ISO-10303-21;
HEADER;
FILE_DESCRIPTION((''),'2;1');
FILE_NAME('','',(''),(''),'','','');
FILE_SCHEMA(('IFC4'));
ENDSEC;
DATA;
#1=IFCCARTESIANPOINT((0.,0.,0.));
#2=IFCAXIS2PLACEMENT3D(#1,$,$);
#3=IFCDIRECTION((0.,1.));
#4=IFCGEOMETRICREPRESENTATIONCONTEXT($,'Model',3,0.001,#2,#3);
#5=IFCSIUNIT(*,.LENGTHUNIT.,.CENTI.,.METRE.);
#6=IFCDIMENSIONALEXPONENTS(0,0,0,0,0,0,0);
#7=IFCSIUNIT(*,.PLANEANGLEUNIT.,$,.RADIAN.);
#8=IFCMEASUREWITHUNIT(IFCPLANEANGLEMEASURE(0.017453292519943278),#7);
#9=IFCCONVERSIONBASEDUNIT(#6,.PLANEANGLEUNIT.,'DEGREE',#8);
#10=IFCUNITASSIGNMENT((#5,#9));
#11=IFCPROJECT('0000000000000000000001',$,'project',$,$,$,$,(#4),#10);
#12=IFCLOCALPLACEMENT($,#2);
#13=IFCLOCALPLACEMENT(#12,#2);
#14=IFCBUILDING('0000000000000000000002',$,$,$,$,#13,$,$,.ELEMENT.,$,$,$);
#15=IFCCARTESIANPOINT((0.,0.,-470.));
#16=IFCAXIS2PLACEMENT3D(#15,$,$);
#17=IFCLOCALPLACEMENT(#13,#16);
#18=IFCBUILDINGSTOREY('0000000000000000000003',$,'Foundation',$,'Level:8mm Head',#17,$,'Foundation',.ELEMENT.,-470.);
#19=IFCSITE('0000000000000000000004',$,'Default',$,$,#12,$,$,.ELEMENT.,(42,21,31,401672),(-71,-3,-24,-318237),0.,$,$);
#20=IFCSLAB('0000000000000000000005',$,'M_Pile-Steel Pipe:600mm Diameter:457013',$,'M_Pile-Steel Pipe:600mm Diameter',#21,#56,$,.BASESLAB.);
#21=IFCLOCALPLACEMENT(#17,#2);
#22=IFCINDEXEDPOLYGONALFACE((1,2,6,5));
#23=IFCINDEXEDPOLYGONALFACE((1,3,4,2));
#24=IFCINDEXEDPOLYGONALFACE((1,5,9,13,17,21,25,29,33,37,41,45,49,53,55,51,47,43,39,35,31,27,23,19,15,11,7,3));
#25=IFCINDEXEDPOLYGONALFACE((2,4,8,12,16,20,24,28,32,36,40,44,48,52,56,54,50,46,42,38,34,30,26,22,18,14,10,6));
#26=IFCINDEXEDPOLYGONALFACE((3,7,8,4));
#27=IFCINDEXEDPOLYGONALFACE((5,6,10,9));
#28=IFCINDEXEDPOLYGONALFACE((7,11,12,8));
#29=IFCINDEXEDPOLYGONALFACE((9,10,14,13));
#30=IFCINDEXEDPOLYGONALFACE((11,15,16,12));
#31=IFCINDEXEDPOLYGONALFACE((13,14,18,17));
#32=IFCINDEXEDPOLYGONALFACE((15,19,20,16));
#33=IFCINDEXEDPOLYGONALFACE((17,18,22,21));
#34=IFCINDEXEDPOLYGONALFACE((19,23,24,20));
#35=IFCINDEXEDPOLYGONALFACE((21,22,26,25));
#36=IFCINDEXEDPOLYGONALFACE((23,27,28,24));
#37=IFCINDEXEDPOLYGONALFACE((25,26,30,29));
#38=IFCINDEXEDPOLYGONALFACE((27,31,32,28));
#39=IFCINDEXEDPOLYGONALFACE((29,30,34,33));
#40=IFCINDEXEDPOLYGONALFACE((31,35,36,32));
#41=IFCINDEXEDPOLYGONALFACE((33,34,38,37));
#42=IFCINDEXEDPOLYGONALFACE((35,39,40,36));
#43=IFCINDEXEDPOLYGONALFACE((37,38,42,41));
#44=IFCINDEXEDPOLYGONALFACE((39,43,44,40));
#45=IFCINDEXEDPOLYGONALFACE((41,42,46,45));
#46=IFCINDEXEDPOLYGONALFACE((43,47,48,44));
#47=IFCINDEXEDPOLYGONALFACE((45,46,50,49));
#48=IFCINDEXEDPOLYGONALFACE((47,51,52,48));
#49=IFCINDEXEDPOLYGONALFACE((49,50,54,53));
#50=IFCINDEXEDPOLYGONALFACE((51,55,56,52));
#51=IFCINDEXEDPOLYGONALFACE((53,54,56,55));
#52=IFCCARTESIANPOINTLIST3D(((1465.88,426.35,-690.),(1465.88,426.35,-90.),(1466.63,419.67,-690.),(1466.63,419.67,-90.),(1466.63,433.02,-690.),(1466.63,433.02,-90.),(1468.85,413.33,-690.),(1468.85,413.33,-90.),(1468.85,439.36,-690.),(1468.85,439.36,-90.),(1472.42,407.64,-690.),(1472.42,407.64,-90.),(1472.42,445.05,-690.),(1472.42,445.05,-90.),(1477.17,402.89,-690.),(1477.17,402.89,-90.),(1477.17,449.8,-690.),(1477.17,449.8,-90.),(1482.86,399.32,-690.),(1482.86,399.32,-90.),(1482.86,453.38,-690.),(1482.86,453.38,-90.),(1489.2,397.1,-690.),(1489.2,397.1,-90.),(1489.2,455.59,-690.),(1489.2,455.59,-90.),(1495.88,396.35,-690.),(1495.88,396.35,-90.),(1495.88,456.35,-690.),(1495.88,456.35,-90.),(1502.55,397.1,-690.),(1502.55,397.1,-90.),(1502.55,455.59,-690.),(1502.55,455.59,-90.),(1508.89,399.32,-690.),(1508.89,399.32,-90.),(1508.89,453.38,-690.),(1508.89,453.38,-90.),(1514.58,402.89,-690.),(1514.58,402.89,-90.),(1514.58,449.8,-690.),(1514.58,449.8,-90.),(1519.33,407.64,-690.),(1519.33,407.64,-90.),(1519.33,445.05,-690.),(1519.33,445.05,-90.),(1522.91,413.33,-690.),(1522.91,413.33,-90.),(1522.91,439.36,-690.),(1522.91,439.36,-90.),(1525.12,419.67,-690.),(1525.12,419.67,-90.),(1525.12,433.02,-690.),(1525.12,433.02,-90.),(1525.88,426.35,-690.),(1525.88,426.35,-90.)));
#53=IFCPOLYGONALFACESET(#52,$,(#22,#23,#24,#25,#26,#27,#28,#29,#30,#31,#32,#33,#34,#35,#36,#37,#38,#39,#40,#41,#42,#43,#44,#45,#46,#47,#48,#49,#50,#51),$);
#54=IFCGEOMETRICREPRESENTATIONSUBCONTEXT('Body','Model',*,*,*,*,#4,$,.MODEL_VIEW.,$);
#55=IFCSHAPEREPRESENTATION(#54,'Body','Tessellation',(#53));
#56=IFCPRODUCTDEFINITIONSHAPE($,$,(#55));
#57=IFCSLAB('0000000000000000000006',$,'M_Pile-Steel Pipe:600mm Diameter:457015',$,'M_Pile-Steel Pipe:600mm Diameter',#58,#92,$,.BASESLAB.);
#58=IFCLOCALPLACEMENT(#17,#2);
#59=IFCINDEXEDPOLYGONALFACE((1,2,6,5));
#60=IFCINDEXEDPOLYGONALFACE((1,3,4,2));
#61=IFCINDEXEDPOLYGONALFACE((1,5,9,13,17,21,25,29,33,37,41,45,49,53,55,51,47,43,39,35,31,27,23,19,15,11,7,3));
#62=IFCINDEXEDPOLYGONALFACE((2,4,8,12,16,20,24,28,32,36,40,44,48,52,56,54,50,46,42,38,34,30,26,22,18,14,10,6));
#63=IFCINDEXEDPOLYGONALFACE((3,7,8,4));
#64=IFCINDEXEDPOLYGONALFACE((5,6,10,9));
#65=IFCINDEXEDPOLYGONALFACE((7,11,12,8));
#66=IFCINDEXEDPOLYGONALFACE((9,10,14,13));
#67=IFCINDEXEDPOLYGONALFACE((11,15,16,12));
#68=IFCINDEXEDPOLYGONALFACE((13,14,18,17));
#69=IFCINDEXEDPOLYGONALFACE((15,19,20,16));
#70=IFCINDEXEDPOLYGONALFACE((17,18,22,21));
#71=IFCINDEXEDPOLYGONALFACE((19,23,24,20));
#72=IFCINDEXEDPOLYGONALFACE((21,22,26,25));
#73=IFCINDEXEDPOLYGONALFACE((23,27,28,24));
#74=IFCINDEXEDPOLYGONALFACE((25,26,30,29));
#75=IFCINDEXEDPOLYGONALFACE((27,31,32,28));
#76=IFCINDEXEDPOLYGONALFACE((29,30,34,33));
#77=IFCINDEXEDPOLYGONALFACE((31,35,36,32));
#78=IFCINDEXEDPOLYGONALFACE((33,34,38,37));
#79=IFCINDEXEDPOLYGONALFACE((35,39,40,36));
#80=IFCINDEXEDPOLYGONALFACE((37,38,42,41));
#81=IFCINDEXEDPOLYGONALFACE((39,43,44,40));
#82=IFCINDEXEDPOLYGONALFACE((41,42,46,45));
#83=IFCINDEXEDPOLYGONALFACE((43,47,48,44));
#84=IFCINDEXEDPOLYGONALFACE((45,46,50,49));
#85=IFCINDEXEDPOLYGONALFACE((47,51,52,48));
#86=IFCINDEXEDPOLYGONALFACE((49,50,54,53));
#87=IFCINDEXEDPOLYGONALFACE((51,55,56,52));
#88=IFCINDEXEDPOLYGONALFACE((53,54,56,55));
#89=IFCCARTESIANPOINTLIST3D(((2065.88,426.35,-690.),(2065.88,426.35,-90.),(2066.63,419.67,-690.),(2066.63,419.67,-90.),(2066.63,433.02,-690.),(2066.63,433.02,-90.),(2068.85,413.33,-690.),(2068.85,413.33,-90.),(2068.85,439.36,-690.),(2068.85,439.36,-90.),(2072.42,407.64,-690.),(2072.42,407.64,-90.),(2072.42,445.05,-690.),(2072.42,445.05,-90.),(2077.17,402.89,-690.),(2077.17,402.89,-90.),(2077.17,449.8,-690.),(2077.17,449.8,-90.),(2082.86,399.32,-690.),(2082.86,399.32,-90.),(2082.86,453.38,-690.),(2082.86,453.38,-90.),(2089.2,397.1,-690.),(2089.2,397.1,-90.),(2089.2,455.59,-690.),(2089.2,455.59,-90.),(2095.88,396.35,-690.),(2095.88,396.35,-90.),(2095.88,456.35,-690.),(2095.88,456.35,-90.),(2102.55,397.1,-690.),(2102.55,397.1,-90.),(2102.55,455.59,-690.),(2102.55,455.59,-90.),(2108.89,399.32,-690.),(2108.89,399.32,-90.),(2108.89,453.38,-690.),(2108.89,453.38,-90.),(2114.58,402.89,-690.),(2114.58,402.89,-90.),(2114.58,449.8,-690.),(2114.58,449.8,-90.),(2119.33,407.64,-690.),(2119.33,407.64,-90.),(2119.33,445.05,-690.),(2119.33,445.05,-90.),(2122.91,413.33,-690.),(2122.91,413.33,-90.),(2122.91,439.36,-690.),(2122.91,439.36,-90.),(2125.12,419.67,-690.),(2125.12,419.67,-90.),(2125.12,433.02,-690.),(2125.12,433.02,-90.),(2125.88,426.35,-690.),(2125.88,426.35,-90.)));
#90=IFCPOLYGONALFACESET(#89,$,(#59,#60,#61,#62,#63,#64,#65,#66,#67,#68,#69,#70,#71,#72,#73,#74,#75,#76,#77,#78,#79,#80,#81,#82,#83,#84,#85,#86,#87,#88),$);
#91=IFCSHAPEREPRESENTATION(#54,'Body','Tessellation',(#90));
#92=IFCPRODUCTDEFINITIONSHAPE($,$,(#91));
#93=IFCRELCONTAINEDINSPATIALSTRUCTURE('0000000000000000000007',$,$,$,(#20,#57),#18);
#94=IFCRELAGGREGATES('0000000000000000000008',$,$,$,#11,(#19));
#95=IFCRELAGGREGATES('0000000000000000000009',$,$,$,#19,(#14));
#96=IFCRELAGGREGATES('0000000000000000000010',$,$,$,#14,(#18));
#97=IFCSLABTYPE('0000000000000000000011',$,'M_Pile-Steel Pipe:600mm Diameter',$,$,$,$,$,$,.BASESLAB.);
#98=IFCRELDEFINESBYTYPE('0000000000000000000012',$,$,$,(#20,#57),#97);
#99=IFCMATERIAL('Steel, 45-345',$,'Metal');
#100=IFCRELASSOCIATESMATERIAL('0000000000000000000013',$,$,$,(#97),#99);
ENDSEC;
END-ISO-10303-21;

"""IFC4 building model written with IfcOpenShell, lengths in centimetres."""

from ifc_helpers import new_model, entity, si_unit, converted_unit, direction, frame, origin, place, context, subcontext, project, spatial, arc, indexed_curve, outline, extrude, material, type_object, element, save


model = new_model("IFC4")

# Units and contexts
model_context = context("Model", 3, precision=0.001, world=origin(), true_north=direction((0.0, 1.0)))
body_context = subcontext(model_context, "Body", "Model", "MODEL_VIEW")
ifc_project = project(units=[si_unit("LENGTHUNIT", "METRE", prefix="CENTI"), converted_unit("PLANEANGLEUNIT", "DEGREE", entity("IfcPlaneAngleMeasure", 0.017453292519943278), si_unit("PLANEANGLEUNIT", "RADIAN"), dimensions=[0, 0, 0, 0, 0, 0, 0])], contexts=[model_context])

# Site, building, storey
site_placement = place(None, origin())
site = spatial("IfcSite", under=ifc_project, at=site_placement, Name="Default", CompositionType="ELEMENT", RefLatitude=(42, 21, 31, 401672), RefLongitude=(-71, -3, -24, -318237), RefElevation=0.0)
building_placement = place(site_placement, origin())
building = spatial("IfcBuilding", under=site, at=building_placement, CompositionType="ELEMENT")
storey_placement = place(building_placement, frame((0.0, 0.0, -470.0)))
storey = spatial("IfcBuildingStorey", under=building, at=storey_placement, Name="Foundation", ObjectType="Level:8mm Head", LongName="Foundation", CompositionType="ELEMENT", Elevation=-470.0)

# Slabs
ifc_material_1 = material(Name="Steel, 45-345", Category="Metal")
slab_type_1 = type_object("IfcSlabType", Name="M_Pile-Steel Pipe:600mm Diameter", PredefinedType="BASESLAB", material=ifc_material_1)
slab_1_placement = place(storey_placement, origin())
element("IfcSlab", 1, at=slab_1_placement, inside=storey, type_object=slab_type_1, Name="M_Pile-Steel Pipe:600mm Diameter:457013", ObjectType="M_Pile-Steel Pipe:600mm Diameter", PredefinedType="BASESLAB", context=body_context, shape_type="SweptSolid", body=[
    extrude(outline(indexed_curve([(-30.0, 0.0), (0.0, -30.0), (30.0, 0.0), (0.0, 30.0)], segments=[arc(1, 2, 3), arc(3, 4, 1)], self_intersect=False)), frame((1495.88, 426.35, -690.0)), (0.0, 0.0, 1.0), 600.0),
])
slab_2_placement = place(storey_placement, origin())
element("IfcSlab", 2, at=slab_2_placement, inside=storey, type_object=slab_type_1, Name="M_Pile-Steel Pipe:600mm Diameter:457015", ObjectType="M_Pile-Steel Pipe:600mm Diameter", PredefinedType="BASESLAB", context=body_context, shape_type="SweptSolid", body=[
    extrude(outline(indexed_curve([(-30.0, 0.0), (0.0, -30.0), (30.0, 0.0), (0.0, 30.0)], segments=[arc(1, 2, 3), arc(3, 4, 1)], self_intersect=False)), frame((2095.88, 426.35, -690.0)), (0.0, 0.0, 1.0), 600.0),
])

save(model, "model.ifc")
